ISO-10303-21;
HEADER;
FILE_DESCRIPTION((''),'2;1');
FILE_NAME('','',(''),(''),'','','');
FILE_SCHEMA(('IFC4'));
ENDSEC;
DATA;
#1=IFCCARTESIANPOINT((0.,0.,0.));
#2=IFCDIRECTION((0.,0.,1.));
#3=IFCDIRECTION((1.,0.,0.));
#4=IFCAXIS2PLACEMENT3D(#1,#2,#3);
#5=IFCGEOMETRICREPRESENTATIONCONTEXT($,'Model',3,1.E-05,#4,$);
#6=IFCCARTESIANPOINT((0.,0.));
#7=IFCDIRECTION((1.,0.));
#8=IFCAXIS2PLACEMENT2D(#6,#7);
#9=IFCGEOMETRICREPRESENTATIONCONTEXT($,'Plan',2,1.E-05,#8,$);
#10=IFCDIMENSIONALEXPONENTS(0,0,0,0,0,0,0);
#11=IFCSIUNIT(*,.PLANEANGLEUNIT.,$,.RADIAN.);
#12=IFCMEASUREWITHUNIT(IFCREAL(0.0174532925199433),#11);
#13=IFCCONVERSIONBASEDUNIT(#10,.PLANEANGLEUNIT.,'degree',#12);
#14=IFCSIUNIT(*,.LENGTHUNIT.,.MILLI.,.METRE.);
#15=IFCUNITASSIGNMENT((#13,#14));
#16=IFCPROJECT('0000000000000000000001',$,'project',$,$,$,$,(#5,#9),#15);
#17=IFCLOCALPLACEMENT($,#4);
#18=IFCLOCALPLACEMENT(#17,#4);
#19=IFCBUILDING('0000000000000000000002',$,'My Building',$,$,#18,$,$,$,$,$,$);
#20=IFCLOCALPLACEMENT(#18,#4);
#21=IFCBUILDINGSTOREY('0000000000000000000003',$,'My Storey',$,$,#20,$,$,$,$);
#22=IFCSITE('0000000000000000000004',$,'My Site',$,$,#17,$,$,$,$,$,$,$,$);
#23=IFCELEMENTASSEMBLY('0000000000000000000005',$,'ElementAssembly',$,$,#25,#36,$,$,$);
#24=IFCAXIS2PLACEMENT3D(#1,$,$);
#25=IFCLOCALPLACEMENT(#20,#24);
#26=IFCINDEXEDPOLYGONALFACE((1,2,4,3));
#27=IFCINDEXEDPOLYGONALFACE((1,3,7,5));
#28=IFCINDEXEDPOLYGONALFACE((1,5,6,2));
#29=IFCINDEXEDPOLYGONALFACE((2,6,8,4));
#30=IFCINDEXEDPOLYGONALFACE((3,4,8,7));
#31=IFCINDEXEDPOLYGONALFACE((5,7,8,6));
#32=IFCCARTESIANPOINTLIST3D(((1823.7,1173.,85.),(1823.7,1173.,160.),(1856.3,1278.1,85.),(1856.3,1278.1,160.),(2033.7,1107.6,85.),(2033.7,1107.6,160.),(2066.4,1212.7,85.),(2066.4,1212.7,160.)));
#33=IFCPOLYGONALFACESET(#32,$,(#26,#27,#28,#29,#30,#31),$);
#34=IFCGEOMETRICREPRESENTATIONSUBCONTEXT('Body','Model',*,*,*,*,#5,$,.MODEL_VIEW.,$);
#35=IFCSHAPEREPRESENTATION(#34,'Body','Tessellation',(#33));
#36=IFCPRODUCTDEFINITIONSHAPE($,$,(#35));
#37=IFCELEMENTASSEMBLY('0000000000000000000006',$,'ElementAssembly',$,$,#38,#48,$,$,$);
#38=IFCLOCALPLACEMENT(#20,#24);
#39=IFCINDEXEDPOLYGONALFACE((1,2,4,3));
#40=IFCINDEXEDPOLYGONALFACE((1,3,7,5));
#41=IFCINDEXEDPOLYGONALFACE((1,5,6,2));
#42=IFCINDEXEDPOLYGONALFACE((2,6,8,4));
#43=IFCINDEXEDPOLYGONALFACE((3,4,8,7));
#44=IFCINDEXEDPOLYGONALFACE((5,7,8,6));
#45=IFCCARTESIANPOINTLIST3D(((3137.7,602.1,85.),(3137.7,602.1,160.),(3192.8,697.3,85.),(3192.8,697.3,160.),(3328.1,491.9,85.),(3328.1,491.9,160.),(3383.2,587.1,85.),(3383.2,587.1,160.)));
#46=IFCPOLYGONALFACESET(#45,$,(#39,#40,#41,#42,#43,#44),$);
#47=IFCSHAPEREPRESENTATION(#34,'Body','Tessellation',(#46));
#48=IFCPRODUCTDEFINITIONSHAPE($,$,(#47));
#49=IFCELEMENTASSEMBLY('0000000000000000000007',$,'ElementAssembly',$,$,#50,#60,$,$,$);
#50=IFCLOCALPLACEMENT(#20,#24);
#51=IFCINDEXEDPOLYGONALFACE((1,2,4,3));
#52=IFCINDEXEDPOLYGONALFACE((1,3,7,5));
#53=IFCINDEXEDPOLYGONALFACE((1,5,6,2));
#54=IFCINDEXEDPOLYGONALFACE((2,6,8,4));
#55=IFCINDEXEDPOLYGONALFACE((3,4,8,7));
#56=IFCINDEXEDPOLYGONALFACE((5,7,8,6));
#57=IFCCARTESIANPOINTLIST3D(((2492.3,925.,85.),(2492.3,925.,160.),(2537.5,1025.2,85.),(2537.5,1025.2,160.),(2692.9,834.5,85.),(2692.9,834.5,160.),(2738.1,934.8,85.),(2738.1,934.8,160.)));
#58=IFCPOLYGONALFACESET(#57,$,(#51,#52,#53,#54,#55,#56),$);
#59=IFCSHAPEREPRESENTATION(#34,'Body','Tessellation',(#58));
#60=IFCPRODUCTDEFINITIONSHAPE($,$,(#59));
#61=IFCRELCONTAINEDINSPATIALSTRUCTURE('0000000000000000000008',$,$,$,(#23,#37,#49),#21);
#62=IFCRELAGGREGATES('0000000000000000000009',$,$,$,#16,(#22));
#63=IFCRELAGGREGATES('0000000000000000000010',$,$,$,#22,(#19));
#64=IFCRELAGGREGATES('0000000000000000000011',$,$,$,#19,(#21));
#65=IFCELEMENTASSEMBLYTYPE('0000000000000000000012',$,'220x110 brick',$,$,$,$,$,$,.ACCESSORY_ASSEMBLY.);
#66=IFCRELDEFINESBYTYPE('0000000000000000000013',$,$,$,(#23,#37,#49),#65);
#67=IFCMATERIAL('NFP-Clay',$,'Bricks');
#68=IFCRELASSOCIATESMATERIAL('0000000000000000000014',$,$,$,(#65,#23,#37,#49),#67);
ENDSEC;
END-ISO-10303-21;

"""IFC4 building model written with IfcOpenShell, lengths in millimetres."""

from ifc_helpers import new_model, entity, si_unit, converted_unit, frame, origin_with_axes, origin_2d_with_axis, place, context, subcontext, project, spatial, rectangle, extrude, material, material_profile, profile_set, profile_usage, type_object, element, save


model = new_model("IFC4")

# Units and contexts
model_context = context("Model", 3, precision=1e-05, world=origin_with_axes())
plan_context = context("Plan", 2, precision=1e-05, world=origin_2d_with_axis())
body_context = subcontext(model_context, "Body", "Model", "MODEL_VIEW")
ifc_project = project(units=[converted_unit("PLANEANGLEUNIT", "degree", entity("IfcReal", 0.0174532925199433), si_unit("PLANEANGLEUNIT", "RADIAN"), dimensions=[0, 0, 0, 0, 0, 0, 0]), si_unit("LENGTHUNIT", "METRE", prefix="MILLI")], contexts=[model_context, plan_context])

# Site, building, storey
site_placement = place(None, origin_with_axes())
site = spatial("IfcSite", under=ifc_project, at=site_placement, Name="My Site")
building_placement = place(site_placement, origin_with_axes())
building = spatial("IfcBuilding", under=site, at=building_placement, Name="My Building")
storey_placement = place(building_placement, origin_with_axes())
storey = spatial("IfcBuildingStorey", under=building, at=storey_placement, Name="My Storey")

# Element assemblies
ifc_material_1 = material(Name="NFP-Clay", Category="Bricks")
ifc_material_profile_1 = material_profile(ifc_material_1, rectangle(XDim=220.0, YDim=110.0))
ifc_profile_set_1 = profile_set([ifc_material_profile_1])
element_assembly_type_1 = type_object("IfcElementAssemblyType", Name="220x110 brick", PredefinedType="ACCESSORY_ASSEMBLY", material=ifc_profile_set_1)
ifc_profile_usage_1 = profile_usage(ifc_profile_set_1, cardinal=5)
assembly_1_placement = place(storey_placement, frame((1945.0, 1192.9, 85.0), z_axis=(0.0, 0.0, 1.0), x_axis=(0.954797, -0.297258, 0.0)))
element("IfcElementAssembly", 1, at=assembly_1_placement, inside=storey, type_object=element_assembly_type_1, material=ifc_profile_usage_1, Name="ElementAssembly", context=body_context, shape_type="SweptSolid", body=[
    extrude(rectangle(XDim=220.0, YDim=110.0), origin_with_axes(), (0.0, 0.0, 1.0), 75.0),
])
ifc_profile_usage_2 = profile_usage(ifc_profile_set_1, cardinal=5)
assembly_2_placement = place(storey_placement, frame((3260.5, 594.6, 85.0), z_axis=(0.0, 0.0, 1.0), x_axis=(0.865376, -0.501123, 0.0)))
element("IfcElementAssembly", 2, at=assembly_2_placement, inside=storey, type_object=element_assembly_type_1, material=ifc_profile_usage_2, Name="ElementAssembly", context=body_context, shape_type="SweptSolid", body=[
    extrude(rectangle(XDim=220.0, YDim=110.0), origin_with_axes(), (0.0, 0.0, 1.0), 75.0),
])
ifc_profile_usage_3 = profile_usage(ifc_profile_set_1, cardinal=5)
assembly_3_placement = place(storey_placement, frame((2615.2, 929.9, 85.0), z_axis=(0.0, 0.0, 1.0), x_axis=(0.911638, -0.410994, 0.0)))
element("IfcElementAssembly", 3, at=assembly_3_placement, inside=storey, type_object=element_assembly_type_1, material=ifc_profile_usage_3, Name="ElementAssembly", context=body_context, shape_type="SweptSolid", body=[
    extrude(rectangle(XDim=220.0, YDim=110.0), origin_with_axes(), (0.0, 0.0, 1.0), 75.0),
])

save(model, "model.ifc")
